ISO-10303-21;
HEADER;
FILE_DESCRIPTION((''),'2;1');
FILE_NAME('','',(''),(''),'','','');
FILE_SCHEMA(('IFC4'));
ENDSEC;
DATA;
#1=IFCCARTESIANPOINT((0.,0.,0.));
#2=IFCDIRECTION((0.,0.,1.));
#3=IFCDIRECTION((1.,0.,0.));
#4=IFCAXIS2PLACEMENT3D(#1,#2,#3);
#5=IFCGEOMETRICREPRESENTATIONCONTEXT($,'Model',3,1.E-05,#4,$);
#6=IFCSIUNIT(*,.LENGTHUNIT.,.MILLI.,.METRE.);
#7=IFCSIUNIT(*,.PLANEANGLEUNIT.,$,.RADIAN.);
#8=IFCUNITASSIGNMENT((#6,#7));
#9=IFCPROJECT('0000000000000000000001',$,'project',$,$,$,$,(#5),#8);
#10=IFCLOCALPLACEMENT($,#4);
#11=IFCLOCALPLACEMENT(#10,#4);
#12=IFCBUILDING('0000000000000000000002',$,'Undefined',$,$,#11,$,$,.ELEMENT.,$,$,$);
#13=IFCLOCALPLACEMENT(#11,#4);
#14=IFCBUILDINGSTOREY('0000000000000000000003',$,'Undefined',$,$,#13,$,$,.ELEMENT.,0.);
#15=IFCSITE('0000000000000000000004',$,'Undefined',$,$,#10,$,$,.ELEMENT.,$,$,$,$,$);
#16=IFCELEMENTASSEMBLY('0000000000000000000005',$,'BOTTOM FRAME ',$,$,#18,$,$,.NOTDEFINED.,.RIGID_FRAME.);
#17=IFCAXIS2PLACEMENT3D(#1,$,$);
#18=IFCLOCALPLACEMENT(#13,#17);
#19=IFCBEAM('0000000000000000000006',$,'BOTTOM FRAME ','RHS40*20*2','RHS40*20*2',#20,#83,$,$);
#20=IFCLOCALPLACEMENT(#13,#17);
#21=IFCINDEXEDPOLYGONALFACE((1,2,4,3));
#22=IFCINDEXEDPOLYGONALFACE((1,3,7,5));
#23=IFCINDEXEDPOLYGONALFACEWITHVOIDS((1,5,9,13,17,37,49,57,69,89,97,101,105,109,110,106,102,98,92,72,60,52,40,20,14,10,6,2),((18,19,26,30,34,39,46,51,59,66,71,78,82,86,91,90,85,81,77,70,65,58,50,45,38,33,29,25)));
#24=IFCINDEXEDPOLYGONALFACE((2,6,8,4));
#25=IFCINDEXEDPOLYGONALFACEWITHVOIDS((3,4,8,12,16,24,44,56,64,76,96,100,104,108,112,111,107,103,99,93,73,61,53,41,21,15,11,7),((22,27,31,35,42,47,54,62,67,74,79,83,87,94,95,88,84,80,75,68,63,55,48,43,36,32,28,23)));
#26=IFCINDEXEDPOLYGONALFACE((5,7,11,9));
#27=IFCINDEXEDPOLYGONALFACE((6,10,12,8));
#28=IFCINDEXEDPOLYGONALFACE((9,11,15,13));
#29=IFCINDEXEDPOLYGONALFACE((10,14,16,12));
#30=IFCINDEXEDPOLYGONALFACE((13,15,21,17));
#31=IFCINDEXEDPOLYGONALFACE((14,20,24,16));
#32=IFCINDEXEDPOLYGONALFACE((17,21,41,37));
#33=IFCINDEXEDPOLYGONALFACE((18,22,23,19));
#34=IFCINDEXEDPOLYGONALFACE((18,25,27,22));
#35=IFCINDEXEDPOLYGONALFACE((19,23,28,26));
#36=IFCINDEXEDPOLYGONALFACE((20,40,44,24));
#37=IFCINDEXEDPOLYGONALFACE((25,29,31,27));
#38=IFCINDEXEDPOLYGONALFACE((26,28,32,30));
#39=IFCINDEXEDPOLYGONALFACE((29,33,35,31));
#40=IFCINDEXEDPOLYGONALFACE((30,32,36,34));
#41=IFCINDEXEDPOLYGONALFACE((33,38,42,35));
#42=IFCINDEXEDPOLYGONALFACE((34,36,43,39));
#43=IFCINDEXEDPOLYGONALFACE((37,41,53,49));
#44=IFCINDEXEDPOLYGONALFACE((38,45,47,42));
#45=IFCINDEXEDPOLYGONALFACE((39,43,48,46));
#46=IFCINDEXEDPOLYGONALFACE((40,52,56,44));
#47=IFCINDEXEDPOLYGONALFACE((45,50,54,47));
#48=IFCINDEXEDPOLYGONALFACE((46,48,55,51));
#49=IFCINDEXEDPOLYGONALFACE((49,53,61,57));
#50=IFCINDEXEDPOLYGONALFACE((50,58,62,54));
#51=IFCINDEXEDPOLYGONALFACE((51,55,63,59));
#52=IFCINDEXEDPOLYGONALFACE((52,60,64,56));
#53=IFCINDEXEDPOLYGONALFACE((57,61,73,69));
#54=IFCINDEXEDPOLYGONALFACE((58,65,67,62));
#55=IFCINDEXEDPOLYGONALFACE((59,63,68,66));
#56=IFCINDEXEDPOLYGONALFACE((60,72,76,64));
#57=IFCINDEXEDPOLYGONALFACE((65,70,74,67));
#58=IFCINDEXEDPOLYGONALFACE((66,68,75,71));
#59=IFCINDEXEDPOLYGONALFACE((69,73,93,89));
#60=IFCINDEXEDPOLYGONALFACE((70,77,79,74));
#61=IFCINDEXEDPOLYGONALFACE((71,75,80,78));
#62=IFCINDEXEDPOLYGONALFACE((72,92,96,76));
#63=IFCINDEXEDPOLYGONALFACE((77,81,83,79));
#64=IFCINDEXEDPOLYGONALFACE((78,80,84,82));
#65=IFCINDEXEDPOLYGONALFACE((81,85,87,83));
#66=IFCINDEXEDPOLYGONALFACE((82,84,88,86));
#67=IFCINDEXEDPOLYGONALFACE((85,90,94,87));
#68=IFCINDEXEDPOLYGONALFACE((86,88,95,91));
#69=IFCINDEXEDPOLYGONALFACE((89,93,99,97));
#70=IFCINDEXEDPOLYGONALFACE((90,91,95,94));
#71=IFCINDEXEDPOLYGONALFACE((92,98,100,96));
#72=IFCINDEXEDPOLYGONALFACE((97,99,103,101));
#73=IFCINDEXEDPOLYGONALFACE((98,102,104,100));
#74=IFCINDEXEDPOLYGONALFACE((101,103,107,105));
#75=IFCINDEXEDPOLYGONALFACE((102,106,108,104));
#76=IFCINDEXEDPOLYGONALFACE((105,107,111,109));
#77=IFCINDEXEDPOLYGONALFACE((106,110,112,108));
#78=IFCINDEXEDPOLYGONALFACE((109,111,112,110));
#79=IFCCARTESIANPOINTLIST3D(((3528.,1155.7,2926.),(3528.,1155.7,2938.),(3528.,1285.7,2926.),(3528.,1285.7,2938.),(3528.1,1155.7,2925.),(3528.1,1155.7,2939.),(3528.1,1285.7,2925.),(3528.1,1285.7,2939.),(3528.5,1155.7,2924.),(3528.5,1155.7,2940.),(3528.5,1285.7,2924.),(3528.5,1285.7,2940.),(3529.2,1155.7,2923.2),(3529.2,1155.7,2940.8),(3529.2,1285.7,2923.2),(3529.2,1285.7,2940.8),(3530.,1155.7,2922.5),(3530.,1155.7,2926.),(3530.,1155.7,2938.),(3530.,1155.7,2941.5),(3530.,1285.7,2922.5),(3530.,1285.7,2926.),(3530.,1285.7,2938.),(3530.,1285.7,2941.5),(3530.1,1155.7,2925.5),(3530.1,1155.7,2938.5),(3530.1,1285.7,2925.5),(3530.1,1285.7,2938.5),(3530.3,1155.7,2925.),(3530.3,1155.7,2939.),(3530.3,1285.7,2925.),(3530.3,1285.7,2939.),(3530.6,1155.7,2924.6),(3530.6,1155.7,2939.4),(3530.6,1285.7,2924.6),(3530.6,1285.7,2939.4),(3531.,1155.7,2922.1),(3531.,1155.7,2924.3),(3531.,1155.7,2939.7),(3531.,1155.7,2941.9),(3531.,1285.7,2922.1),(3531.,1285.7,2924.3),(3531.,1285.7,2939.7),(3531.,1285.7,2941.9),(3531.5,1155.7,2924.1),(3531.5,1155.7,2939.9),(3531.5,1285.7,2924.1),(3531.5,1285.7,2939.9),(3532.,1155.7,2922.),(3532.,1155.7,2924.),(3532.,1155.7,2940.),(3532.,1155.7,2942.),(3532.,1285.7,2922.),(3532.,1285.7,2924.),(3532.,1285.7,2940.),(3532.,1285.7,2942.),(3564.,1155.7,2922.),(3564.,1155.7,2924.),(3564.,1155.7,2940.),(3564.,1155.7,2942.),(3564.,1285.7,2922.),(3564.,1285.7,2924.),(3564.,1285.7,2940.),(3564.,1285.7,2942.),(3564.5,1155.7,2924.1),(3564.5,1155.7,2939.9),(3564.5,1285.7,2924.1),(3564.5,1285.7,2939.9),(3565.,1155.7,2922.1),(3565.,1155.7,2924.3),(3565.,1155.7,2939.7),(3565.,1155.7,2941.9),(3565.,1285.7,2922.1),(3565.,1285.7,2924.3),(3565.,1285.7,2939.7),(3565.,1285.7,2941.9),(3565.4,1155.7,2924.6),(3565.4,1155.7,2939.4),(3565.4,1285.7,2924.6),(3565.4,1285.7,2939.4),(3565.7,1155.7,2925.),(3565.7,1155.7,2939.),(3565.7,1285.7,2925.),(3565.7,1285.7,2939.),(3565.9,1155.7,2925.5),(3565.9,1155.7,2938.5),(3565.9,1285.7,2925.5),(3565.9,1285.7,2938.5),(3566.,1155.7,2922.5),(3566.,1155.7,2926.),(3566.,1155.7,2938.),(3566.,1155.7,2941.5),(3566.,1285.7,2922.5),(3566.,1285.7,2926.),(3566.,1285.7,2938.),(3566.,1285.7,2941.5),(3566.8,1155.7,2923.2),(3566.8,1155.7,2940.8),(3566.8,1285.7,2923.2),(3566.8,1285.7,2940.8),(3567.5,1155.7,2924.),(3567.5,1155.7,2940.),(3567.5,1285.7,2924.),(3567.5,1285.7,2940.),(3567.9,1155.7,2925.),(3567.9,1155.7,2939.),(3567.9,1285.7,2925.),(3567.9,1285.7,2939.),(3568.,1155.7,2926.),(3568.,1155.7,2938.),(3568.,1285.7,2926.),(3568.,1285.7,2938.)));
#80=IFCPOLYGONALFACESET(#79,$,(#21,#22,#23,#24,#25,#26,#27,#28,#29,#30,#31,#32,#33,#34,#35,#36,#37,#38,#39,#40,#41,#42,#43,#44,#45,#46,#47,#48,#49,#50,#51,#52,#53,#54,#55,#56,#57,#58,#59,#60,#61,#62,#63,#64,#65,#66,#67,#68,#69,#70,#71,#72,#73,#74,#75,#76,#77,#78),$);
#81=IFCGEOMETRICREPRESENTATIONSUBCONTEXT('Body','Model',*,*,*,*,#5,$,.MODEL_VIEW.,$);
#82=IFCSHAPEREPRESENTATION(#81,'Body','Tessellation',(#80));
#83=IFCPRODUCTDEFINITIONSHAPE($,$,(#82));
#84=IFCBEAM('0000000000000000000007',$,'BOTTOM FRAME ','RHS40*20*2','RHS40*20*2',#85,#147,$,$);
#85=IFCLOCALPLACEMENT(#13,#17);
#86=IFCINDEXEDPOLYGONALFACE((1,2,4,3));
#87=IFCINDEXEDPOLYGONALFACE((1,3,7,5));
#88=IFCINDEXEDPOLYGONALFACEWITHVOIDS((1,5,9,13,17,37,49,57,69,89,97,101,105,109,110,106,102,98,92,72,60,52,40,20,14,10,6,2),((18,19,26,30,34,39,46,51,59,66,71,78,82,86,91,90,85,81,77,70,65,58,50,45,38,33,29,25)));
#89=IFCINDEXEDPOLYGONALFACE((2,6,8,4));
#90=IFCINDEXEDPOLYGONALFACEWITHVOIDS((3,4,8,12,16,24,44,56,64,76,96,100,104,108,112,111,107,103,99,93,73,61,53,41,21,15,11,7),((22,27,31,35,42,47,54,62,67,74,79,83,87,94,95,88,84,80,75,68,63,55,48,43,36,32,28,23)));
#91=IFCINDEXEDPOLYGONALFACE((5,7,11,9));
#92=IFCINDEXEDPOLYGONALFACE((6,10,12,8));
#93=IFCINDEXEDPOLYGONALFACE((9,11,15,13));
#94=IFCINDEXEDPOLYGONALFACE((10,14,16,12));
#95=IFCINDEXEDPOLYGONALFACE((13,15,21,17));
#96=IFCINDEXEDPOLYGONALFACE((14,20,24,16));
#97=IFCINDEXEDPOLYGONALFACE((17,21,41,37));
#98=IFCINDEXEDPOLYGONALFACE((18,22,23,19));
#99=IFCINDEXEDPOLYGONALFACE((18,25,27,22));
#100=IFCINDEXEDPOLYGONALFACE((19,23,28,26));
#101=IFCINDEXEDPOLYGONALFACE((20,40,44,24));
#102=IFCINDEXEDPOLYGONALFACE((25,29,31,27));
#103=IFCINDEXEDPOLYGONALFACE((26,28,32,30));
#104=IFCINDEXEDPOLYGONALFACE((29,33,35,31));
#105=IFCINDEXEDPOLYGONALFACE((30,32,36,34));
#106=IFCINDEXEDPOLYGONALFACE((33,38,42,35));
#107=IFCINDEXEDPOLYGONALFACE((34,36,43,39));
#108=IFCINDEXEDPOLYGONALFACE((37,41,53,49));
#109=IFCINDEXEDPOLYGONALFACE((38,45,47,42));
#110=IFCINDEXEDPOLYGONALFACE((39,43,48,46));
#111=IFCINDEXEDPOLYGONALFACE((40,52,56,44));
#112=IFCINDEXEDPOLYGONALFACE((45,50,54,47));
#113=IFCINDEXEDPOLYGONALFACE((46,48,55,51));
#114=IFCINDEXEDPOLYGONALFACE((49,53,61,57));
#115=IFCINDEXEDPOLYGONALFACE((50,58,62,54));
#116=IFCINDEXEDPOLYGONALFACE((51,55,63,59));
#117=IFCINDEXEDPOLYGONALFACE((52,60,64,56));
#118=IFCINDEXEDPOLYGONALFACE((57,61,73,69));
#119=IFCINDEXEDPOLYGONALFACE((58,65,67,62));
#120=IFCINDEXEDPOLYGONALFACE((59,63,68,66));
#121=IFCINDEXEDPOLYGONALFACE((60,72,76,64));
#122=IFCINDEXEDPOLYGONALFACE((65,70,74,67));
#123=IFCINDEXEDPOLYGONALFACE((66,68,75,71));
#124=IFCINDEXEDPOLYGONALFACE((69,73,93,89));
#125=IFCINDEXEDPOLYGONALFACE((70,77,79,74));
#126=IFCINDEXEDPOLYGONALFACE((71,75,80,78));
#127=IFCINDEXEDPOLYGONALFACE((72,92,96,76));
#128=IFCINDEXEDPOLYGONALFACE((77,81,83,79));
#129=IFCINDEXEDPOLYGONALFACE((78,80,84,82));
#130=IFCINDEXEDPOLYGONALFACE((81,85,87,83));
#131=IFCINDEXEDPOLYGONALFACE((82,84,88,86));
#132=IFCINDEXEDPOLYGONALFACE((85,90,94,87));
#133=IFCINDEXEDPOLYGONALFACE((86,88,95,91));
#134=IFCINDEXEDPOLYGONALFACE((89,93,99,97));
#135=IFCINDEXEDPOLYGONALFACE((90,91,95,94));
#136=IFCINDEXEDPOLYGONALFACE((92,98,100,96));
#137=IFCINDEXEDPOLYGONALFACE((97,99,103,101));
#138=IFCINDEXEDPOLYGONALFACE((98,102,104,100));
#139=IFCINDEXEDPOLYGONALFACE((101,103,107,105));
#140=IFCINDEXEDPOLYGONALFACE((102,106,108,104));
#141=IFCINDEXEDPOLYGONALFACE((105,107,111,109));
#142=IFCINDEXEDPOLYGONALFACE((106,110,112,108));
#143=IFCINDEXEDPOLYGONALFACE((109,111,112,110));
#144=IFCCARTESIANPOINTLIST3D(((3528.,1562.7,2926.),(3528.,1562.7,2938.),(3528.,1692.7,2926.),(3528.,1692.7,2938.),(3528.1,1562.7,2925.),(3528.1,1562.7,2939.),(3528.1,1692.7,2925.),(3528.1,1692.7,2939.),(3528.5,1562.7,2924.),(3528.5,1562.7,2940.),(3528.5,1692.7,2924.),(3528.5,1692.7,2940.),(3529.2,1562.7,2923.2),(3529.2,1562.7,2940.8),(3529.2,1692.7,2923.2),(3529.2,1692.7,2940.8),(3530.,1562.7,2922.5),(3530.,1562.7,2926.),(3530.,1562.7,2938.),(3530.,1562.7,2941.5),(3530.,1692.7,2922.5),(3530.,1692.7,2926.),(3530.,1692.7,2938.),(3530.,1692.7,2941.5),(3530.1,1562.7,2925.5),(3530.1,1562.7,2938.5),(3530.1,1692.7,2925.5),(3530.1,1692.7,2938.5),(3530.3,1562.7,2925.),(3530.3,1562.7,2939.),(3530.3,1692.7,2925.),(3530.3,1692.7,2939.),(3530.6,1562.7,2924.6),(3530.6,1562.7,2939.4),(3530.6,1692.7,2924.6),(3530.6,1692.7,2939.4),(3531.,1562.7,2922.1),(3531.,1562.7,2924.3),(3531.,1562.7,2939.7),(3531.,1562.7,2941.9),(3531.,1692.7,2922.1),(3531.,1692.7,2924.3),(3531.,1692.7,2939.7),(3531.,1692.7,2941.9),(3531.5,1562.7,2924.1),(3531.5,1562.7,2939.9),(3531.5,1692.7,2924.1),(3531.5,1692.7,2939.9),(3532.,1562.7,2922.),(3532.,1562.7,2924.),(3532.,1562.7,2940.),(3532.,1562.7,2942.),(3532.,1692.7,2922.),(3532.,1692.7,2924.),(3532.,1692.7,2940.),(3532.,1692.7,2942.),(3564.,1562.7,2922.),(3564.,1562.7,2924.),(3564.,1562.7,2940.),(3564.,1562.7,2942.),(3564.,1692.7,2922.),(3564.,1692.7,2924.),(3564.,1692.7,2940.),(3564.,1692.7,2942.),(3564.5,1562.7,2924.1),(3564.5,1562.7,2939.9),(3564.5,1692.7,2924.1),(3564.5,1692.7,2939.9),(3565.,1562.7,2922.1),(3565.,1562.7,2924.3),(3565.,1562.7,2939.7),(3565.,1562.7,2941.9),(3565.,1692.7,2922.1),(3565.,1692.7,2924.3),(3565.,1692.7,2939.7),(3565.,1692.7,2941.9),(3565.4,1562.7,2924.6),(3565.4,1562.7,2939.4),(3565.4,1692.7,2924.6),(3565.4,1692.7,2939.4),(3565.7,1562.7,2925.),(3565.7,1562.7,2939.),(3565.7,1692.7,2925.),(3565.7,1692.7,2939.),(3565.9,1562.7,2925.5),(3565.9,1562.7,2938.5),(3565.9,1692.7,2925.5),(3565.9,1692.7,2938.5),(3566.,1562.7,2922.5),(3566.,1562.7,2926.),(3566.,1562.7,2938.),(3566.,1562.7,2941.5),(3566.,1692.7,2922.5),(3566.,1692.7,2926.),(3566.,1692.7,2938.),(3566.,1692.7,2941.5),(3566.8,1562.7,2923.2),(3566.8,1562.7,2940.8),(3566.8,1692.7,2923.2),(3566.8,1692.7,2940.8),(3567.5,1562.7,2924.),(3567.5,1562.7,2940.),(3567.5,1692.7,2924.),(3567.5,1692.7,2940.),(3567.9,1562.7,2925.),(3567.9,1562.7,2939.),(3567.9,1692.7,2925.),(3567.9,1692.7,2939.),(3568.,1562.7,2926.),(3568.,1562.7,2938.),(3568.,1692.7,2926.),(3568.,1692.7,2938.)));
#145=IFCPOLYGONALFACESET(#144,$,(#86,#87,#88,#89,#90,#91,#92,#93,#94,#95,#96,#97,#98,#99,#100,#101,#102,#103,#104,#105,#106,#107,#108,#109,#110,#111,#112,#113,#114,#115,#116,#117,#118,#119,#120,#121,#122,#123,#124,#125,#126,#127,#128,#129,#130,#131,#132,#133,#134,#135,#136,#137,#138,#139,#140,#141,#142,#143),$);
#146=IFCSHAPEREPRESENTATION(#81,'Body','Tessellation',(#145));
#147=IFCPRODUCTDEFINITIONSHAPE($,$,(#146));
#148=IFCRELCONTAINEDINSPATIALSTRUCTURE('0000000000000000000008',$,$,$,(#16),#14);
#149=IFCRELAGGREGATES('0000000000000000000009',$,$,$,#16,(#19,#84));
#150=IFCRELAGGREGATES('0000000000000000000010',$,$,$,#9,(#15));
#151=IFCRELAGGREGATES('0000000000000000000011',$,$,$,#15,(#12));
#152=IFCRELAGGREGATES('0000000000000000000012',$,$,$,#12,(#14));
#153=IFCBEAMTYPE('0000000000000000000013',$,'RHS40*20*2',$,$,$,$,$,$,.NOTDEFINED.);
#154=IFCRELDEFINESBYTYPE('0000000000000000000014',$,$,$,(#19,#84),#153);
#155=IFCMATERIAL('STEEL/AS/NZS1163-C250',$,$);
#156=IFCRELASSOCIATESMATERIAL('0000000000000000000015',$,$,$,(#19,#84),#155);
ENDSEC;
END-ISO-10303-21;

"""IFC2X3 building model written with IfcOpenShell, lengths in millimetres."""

from ifc_helpers import new_model, si_unit, frame, origin_with_axes, origin_2d_with_axis, place, context, subcontext, project, spatial, hollow_rectangle, extrude, material, type_object, element, aggregate, save


model = new_model("IFC2X3")

# Units and contexts
model_context = context("Model", 3, precision=1e-05, world=origin_with_axes())
body_context = subcontext(model_context, "Body", "Model", "MODEL_VIEW")
ifc_project = project(units=[si_unit("LENGTHUNIT", "METRE", prefix="MILLI"), si_unit("PLANEANGLEUNIT", "RADIAN")], contexts=[model_context])

# Site, building, storey
site_placement = place(None, origin_with_axes())
site = spatial("IfcSite", under=ifc_project, at=site_placement, Name="Undefined", CompositionType="ELEMENT")
building_placement = place(site_placement, origin_with_axes())
building = spatial("IfcBuilding", under=site, at=building_placement, Name="Undefined", CompositionType="ELEMENT")
storey_placement = place(building_placement, origin_with_axes())
storey = spatial("IfcBuildingStorey", under=building, at=storey_placement, Name="Undefined", CompositionType="ELEMENT", Elevation=0.0)

# Element assembly, beams
assembly_1_placement = place(storey_placement, origin_with_axes())
assembly_1 = element("IfcElementAssembly", 1, at=assembly_1_placement, inside=storey, Name="BOTTOM FRAME ", AssemblyPlace="NOTDEFINED", PredefinedType="RIGID_FRAME")
ifc_material_1 = material(Name="STEEL/AS/NZS1163-C250")
beam_type_1 = type_object("IfcBeamType", Name="RHS40*20*2", PredefinedType="NOTDEFINED")
beam_1_placement = place(assembly_1_placement, frame((3548.0, 1285.7, 2932.0), z_axis=(1.0, 0.0, 0.0), x_axis=(0.0, -1.0, 0.0)))
beam_1 = element("IfcBeam", 2, at=beam_1_placement, type_object=beam_type_1, material=ifc_material_1, Name="BOTTOM FRAME ", Description="RHS40*20*2", ObjectType="RHS40*20*2", context=body_context, shape_type="SweptSolid", body=[
    extrude(hollow_rectangle(XDim=20.0, YDim=40.0, WallThickness=2.0, InnerFilletRadius=2.0, OuterFilletRadius=4.0, at=origin_2d_with_axis()), frame((130.0, 0.0, 0.0), z_axis=(-1.0, 0.0, 0.0), x_axis=(0.0, -1.0, 0.0)), (0.0, 0.0, 1.0), 130.0),
])
beam_2_placement = place(assembly_1_placement, frame((3548.0, 1692.7, 2932.0), z_axis=(1.0, 0.0, 0.0), x_axis=(0.0, -1.0, 0.0)))
beam_2 = element("IfcBeam", 3, at=beam_2_placement, type_object=beam_type_1, material=ifc_material_1, Name="BOTTOM FRAME ", Description="RHS40*20*2", ObjectType="RHS40*20*2", context=body_context, shape_type="SweptSolid", body=[
    extrude(hollow_rectangle(XDim=20.0, YDim=40.0, WallThickness=2.0, InnerFilletRadius=2.0, OuterFilletRadius=4.0, at=origin_2d_with_axis()), frame((130.0, 0.0, 0.0), z_axis=(-1.0, 0.0, 0.0), x_axis=(0.0, -1.0, 0.0)), (0.0, 0.0, 1.0), 130.0),
])

aggregate(assembly_1, [beam_1, beam_2])

save(model, "model.ifc")
